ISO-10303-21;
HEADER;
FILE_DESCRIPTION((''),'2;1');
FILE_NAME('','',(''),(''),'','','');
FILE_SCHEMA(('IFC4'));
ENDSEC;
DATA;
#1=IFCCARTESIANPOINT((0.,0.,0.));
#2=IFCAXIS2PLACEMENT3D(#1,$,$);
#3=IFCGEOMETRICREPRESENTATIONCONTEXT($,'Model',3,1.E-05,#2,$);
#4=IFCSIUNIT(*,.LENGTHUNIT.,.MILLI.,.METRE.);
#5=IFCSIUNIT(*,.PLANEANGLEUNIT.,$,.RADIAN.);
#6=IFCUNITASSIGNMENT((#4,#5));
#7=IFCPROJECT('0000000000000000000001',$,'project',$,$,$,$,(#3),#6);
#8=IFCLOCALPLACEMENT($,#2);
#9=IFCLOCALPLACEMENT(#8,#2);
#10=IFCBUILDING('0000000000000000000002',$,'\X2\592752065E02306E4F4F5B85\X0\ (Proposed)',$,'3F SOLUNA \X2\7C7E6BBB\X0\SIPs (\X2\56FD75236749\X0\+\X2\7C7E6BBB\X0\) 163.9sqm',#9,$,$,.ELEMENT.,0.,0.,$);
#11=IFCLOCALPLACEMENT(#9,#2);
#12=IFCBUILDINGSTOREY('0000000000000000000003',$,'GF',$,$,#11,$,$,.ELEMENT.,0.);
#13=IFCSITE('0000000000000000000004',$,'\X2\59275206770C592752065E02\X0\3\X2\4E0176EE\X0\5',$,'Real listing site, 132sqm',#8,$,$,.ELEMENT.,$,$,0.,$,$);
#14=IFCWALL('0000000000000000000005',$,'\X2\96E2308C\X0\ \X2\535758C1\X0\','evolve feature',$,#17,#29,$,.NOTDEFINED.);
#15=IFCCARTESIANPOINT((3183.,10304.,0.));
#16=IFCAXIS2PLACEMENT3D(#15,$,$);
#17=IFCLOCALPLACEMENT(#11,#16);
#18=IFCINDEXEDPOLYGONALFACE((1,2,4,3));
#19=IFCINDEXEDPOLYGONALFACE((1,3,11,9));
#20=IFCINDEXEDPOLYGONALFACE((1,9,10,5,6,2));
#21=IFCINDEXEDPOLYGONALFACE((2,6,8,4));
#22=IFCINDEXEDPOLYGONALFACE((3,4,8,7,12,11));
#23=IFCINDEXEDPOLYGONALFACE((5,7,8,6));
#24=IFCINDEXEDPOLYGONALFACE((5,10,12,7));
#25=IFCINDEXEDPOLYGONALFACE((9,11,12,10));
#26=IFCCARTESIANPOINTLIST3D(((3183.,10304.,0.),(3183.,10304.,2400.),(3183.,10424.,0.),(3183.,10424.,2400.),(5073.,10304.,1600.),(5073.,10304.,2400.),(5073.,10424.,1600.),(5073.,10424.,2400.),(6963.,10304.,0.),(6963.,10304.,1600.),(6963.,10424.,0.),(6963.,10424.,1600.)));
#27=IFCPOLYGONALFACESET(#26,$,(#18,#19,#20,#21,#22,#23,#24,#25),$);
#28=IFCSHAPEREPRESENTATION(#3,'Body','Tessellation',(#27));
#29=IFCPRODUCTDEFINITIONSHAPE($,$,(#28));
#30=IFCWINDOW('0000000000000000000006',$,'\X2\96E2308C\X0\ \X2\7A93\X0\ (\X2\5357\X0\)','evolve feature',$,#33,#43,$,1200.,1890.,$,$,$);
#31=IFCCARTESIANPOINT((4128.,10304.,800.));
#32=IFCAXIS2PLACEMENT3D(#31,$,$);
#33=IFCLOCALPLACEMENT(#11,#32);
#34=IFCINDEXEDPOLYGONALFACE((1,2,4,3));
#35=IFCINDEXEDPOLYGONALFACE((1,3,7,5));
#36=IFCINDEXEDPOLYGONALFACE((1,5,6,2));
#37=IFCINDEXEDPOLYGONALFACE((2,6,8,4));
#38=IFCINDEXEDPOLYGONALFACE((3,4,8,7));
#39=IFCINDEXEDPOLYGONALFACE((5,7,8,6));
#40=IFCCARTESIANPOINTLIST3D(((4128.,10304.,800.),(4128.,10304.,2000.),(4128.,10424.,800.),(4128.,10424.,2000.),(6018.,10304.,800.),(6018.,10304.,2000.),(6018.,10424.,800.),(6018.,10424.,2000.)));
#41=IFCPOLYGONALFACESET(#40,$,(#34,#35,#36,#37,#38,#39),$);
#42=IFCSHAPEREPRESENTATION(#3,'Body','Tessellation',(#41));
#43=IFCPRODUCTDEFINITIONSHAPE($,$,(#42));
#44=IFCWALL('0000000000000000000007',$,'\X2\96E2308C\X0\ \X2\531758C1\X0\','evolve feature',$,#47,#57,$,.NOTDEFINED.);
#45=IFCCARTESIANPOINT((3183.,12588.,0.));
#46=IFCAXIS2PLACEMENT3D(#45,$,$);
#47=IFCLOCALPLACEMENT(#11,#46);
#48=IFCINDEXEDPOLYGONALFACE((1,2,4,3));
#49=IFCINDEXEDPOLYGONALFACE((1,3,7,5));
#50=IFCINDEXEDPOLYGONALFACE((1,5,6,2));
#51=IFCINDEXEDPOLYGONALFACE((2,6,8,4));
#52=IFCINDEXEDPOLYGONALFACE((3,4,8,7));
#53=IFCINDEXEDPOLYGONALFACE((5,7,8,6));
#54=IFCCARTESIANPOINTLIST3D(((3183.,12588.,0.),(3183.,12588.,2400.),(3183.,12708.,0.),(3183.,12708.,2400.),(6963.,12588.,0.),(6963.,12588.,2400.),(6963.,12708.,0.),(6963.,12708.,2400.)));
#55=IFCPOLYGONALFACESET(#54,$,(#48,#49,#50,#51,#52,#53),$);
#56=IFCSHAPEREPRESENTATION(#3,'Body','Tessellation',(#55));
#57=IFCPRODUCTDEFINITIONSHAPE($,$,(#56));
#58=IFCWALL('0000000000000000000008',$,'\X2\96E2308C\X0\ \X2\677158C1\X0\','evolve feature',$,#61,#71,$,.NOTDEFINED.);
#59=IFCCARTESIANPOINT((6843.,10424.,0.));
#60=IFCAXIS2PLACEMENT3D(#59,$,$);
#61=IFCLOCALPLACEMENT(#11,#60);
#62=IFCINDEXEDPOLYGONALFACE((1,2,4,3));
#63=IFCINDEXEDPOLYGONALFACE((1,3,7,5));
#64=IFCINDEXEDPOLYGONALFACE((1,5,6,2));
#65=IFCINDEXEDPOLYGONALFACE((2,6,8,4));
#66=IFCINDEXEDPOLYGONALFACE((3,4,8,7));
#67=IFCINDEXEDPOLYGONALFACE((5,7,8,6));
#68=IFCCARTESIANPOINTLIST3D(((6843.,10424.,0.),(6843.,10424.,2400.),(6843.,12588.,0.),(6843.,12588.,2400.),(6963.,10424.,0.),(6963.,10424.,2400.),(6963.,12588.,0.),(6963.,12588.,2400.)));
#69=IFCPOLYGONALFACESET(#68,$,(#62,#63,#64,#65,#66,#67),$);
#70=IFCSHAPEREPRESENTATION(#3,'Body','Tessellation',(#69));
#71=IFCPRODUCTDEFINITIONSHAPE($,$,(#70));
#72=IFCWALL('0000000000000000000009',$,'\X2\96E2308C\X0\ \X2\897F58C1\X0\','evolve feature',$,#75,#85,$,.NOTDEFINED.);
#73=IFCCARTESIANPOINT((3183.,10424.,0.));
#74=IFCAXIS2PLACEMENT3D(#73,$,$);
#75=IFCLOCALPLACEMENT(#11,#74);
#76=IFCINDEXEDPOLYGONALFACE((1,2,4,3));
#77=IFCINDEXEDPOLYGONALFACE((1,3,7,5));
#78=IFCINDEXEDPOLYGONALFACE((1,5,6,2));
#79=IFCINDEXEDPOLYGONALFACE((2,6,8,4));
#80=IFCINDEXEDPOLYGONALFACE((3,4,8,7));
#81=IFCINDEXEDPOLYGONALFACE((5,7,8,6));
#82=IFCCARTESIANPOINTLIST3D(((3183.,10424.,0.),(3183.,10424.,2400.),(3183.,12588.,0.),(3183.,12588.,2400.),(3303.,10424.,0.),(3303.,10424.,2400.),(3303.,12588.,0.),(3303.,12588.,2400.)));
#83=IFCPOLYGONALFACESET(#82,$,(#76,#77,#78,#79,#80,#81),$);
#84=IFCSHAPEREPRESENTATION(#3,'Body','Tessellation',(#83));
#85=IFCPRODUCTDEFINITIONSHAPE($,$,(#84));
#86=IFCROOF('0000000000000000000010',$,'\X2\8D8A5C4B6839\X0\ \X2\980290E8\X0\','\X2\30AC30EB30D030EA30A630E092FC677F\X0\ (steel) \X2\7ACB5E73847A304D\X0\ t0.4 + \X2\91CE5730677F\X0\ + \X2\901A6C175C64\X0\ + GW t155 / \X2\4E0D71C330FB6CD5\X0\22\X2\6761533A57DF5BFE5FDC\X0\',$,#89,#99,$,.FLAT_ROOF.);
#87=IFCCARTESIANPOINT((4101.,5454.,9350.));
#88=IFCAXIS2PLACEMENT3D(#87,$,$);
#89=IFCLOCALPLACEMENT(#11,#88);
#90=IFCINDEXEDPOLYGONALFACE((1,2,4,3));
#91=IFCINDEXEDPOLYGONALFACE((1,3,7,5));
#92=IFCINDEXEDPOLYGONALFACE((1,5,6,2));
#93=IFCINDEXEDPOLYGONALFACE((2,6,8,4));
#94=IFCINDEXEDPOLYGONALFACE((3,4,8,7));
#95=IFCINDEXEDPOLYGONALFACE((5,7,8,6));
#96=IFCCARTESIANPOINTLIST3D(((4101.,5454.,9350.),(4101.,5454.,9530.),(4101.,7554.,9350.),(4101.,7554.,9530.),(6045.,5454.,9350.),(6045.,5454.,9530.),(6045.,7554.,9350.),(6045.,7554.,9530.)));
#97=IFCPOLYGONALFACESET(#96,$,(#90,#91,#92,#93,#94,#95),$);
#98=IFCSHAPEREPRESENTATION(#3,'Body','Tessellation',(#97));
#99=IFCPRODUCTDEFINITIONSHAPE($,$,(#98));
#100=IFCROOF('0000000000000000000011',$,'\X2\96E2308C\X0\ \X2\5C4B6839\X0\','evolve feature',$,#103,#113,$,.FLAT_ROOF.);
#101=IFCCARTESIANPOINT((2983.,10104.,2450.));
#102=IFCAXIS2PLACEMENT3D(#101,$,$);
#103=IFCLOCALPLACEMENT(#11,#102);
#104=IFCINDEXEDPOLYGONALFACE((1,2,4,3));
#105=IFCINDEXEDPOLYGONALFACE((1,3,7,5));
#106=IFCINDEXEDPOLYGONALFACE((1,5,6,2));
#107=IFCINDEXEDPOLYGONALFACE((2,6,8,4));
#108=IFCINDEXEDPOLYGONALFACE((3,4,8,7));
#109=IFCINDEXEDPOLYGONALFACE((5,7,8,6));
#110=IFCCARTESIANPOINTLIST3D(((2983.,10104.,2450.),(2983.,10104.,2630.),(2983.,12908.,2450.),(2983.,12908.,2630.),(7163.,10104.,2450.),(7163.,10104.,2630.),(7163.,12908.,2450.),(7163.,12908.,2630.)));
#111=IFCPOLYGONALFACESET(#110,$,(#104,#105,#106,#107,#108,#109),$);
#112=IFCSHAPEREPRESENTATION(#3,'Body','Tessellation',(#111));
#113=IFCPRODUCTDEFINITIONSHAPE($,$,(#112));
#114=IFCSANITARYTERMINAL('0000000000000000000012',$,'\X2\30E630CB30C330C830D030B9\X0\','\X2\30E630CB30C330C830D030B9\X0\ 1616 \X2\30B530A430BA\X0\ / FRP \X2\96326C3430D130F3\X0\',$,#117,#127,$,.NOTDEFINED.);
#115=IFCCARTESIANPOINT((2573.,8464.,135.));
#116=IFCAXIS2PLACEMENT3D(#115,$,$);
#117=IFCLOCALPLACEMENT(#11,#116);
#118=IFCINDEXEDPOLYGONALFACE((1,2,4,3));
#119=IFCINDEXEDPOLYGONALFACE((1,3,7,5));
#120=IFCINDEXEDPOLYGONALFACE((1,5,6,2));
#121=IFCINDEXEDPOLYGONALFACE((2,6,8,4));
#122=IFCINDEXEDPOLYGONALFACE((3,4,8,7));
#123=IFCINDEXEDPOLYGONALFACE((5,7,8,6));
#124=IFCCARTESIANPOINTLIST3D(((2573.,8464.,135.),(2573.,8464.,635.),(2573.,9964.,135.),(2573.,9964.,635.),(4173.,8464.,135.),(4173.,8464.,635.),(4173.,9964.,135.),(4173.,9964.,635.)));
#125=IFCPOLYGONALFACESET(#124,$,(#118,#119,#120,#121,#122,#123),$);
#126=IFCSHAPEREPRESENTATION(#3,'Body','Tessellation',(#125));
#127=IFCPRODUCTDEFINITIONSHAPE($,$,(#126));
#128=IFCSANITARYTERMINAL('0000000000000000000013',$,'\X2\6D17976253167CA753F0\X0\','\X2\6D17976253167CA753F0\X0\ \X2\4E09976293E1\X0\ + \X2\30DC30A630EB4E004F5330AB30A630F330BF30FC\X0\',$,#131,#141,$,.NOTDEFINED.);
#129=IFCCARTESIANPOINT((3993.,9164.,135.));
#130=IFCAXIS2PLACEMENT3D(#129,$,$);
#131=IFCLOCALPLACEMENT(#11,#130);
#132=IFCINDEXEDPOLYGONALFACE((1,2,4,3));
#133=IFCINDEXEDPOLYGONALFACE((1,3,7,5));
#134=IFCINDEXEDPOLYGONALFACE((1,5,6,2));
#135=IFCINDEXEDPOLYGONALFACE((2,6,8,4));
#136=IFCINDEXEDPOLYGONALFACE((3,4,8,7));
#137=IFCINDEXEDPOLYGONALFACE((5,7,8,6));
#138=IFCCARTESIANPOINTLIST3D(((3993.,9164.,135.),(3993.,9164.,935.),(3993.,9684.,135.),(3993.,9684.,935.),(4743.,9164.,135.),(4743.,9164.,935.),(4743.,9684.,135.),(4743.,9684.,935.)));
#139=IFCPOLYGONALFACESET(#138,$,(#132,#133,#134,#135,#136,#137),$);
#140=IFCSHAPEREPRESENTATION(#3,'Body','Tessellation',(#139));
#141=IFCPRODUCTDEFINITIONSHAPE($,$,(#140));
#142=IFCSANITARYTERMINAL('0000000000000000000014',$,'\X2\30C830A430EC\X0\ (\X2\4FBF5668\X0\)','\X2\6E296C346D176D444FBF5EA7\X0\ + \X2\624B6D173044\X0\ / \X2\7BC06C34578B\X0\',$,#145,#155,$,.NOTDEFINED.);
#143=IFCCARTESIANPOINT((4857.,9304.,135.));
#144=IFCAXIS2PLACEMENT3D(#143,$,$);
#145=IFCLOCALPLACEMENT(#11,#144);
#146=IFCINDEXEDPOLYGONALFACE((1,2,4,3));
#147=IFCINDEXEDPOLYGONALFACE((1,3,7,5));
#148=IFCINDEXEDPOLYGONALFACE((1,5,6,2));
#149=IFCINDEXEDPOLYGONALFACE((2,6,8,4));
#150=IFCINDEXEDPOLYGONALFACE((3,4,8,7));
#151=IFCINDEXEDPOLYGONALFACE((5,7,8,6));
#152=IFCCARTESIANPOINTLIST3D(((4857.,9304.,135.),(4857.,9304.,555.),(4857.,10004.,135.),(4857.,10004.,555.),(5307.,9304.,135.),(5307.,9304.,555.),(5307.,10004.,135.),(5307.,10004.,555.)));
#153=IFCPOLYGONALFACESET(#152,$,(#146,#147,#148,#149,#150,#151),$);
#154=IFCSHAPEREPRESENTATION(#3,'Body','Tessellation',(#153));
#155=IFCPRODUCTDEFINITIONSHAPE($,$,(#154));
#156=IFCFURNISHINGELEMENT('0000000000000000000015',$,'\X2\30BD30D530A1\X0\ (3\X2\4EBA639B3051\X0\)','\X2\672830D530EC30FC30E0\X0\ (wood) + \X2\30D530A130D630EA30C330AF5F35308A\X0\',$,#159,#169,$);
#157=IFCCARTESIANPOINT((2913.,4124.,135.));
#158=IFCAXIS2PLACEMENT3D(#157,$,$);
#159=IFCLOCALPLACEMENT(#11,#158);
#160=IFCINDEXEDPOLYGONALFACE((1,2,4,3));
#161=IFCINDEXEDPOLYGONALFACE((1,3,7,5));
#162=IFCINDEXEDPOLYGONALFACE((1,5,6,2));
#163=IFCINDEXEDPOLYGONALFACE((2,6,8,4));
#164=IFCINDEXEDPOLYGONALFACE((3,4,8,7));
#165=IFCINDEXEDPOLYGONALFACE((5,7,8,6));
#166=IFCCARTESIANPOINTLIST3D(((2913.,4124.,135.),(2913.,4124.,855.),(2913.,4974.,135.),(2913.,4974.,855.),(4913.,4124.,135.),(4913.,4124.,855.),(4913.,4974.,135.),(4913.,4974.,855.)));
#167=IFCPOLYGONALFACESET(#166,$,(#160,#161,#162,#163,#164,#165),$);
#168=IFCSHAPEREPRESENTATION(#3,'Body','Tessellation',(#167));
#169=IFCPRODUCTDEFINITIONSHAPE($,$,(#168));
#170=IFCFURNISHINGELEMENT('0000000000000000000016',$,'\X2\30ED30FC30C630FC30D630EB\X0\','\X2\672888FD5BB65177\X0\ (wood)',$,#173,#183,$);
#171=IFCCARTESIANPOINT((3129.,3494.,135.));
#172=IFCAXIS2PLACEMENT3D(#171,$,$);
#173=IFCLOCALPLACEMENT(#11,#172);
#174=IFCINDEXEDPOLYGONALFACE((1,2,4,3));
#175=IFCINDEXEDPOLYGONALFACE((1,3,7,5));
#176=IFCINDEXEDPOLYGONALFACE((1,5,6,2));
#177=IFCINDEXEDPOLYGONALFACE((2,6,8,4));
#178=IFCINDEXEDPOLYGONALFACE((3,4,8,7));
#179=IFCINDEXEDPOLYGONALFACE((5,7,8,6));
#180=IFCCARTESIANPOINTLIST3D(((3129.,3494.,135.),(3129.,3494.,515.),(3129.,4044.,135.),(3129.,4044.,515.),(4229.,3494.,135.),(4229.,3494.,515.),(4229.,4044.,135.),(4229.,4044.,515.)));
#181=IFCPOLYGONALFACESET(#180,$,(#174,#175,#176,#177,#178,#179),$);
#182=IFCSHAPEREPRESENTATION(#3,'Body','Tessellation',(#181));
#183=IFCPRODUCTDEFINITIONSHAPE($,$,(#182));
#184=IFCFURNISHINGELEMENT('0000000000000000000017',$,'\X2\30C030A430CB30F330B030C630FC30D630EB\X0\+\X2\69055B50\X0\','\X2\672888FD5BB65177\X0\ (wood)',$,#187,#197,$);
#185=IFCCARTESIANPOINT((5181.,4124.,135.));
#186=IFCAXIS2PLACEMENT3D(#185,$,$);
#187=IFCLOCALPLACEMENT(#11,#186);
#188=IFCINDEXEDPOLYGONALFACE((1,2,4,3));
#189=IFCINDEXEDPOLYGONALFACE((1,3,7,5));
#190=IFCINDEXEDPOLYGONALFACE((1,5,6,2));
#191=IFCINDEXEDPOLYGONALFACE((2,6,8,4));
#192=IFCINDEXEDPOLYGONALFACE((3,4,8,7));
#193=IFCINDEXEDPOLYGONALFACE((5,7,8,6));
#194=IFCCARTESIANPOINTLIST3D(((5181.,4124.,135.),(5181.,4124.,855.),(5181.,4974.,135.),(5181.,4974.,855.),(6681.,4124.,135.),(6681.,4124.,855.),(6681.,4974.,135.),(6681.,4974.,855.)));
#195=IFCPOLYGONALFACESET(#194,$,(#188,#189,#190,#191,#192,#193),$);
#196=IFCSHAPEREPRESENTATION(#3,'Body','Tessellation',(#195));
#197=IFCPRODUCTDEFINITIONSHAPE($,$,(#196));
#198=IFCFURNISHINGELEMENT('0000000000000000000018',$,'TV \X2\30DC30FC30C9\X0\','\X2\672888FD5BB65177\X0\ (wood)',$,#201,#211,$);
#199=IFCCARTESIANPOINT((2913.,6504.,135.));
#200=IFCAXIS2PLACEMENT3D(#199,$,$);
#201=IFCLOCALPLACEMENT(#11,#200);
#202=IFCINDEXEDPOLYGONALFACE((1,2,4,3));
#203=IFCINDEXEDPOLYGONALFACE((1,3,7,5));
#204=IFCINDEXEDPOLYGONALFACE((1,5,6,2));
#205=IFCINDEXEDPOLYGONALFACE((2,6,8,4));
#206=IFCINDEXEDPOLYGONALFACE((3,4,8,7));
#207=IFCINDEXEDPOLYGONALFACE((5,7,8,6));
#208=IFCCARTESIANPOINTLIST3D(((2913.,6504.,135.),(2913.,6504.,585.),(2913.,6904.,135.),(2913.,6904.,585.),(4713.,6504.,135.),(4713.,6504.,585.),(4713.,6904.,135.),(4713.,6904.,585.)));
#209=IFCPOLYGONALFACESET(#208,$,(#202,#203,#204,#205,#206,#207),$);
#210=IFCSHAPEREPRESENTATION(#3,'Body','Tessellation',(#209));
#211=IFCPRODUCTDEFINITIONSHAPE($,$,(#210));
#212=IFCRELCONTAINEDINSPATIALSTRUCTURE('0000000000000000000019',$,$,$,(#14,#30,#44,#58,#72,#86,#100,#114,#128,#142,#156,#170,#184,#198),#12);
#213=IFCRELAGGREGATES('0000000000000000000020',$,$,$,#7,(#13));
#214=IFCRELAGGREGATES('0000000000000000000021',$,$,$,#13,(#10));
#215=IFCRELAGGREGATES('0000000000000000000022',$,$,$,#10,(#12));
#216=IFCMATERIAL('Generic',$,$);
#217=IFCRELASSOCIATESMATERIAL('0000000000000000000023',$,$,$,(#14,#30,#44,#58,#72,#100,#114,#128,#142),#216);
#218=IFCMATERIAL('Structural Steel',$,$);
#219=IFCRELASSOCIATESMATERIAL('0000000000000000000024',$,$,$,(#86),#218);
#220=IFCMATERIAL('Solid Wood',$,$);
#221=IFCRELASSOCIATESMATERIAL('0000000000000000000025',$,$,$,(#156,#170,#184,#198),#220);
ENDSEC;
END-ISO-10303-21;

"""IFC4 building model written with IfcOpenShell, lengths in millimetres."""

from ifc_helpers import new_model, si_unit, frame, frame_2d, origin, place, context, project, spatial, rectangle, extrude, material, element, fill, save


model = new_model("IFC4")

# Units and contexts
model_context = context("Model", 3, precision=1e-05, world=origin())
ifc_project = project(units=[si_unit("LENGTHUNIT", "METRE", prefix="MILLI"), si_unit("PLANEANGLEUNIT", "RADIAN")], contexts=[model_context])

# Site, building, storey
site_placement = place(None, origin())
site = spatial("IfcSite", under=ifc_project, at=site_placement, Name="大分県大分市3丁目5", ObjectType="Real listing site, 132sqm", CompositionType="ELEMENT", RefElevation=0.0)
building_placement = place(site_placement, origin())
building = spatial("IfcBuilding", under=site, at=building_placement, Name="大分市の住宅 (Proposed)", ObjectType="3F SOLUNA 籾殻SIPs (国産杉+籾殻) 163.9sqm", CompositionType="ELEMENT", ElevationOfRefHeight=0.0, ElevationOfTerrain=0.0)
storey_placement = place(building_placement, origin())
storey = spatial("IfcBuildingStorey", under=building, at=storey_placement, Name="GF", CompositionType="ELEMENT", Elevation=0.0)

# Shared definitions
ifc_material_1 = material(Name="Generic")

# Shared definitions
ifc_material_2 = material(Name="Solid Wood")

# Wall, opening, window
wall_1_placement = place(storey_placement, frame((3183.0, 10304.0, 0.0)))
wall_1 = element("IfcWall", 1, at=wall_1_placement, inside=storey, material=ifc_material_1, Name="離れ 南壁", Description="evolve feature", PredefinedType="NOTDEFINED", context=model_context, shape_type="SweptSolid", body=[
    extrude(rectangle(XDim=3780.0, YDim=120.0, at=frame_2d((1890.0, 60.0))), frame((3183.0, 10304.0, 0.0)), (0.0, 0.0, 1.0), 2400.0),
])
opening_1_placement = place(storey_placement, frame((4128.0, 10304.0, 800.0)))
opening_1 = element("IfcOpeningElement", 2, at=opening_1_placement, cuts=wall_1, PredefinedType="NOTDEFINED", context=model_context, shape_type="SweptSolid", body=[
    extrude(rectangle(XDim=1890.0, YDim=120.0, at=frame_2d((945.0, 60.0))), frame((4128.0, 10304.0, 800.0)), (0.0, 0.0, 1.0), 1200.0),
])
window_1_placement = place(storey_placement, frame((4128.0, 10304.0, 800.0)))
window_1 = element("IfcWindow", 3, at=window_1_placement, inside=storey, material=ifc_material_1, Name="離れ 窓 (南)", Description="evolve feature", OverallHeight=1200.0, OverallWidth=1890.0, context=model_context, shape_type="SweptSolid", body=[
    extrude(rectangle(XDim=1890.0, YDim=120.0, at=frame_2d((945.0, 60.0))), frame((4128.0, 10304.0, 800.0)), (0.0, 0.0, 1.0), 1200.0),
])
fill(opening_1, window_1)

# Walls
wall_2_placement = place(storey_placement, frame((3183.0, 12588.0, 0.0)))
element("IfcWall", 4, at=wall_2_placement, inside=storey, material=ifc_material_1, Name="離れ 北壁", Description="evolve feature", PredefinedType="NOTDEFINED", context=model_context, shape_type="SweptSolid", body=[
    extrude(rectangle(XDim=3780.0, YDim=120.0, at=frame_2d((1890.0, 60.0))), frame((3183.0, 12588.0, 0.0)), (0.0, 0.0, 1.0), 2400.0),
])
wall_3_placement = place(storey_placement, frame((6843.0, 10424.0, 0.0)))
element("IfcWall", 5, at=wall_3_placement, inside=storey, material=ifc_material_1, Name="離れ 東壁", Description="evolve feature", PredefinedType="NOTDEFINED", context=model_context, shape_type="SweptSolid", body=[
    extrude(rectangle(XDim=120.0, YDim=2164.0, at=frame_2d((60.0, 1082.0))), frame((6843.0, 10424.0, 0.0)), (0.0, 0.0, 1.0), 2400.0),
])
wall_4_placement = place(storey_placement, frame((3183.0, 10424.0, 0.0)))
element("IfcWall", 6, at=wall_4_placement, inside=storey, material=ifc_material_1, Name="離れ 西壁", Description="evolve feature", PredefinedType="NOTDEFINED", context=model_context, shape_type="SweptSolid", body=[
    extrude(rectangle(XDim=120.0, YDim=2164.0, at=frame_2d((60.0, 1082.0))), frame((3183.0, 10424.0, 0.0)), (0.0, 0.0, 1.0), 2400.0),
])

# Roofs
ifc_material_3 = material(Name="Structural Steel")
roof_1_placement = place(storey_placement, frame((4101.0, 5454.0, 9350.0)))
element("IfcRoof", 7, at=roof_1_placement, inside=storey, material=ifc_material_3, Name="越屋根 頂部", Description="ガルバリウム鋼板 (steel) 立平葺き t0.4 + 野地板 + 通気層 + GW t155 / 不燃・法22条区域対応", PredefinedType="FLAT_ROOF", context=model_context, shape_type="SweptSolid", body=[
    extrude(rectangle(XDim=1944.0, YDim=2100.0, at=frame_2d((972.0, 1050.0))), frame((4101.0, 5454.0, 9350.0)), (0.0, 0.0, 1.0), 180.0),
])
roof_2_placement = place(storey_placement, frame((2983.0, 10104.0, 2450.0)))
element("IfcRoof", 8, at=roof_2_placement, inside=storey, material=ifc_material_1, Name="離れ 屋根", Description="evolve feature", PredefinedType="FLAT_ROOF", context=model_context, shape_type="SweptSolid", body=[
    extrude(rectangle(XDim=4180.0, YDim=2804.0, at=frame_2d((2090.0, 1402.0))), frame((2983.0, 10104.0, 2450.0)), (0.0, 0.0, 1.0), 180.0),
])

# Sanitary terminals
sanitary_terminal_1_placement = place(storey_placement, frame((2573.0, 8464.0, 135.0)))
element("IfcSanitaryTerminal", 9, at=sanitary_terminal_1_placement, inside=storey, material=ifc_material_1, Name="ユニットバス", Description="ユニットバス 1616 サイズ / FRP 防水パン", PredefinedType="NOTDEFINED", context=model_context, shape_type="SweptSolid", body=[
    extrude(rectangle(XDim=1600.0, YDim=1500.0, at=frame_2d((800.0, 750.0))), frame((2573.0, 8464.0, 135.0)), (0.0, 0.0, 1.0), 500.0),
])
sanitary_terminal_2_placement = place(storey_placement, frame((3993.0, 9164.0, 135.0)))
element("IfcSanitaryTerminal", 10, at=sanitary_terminal_2_placement, inside=storey, material=ifc_material_1, Name="洗面化粧台", Description="洗面化粧台 三面鏡 + ボウル一体カウンター", PredefinedType="NOTDEFINED", context=model_context, shape_type="SweptSolid", body=[
    extrude(rectangle(XDim=750.0, YDim=520.0, at=frame_2d((375.0, 260.0))), frame((3993.0, 9164.0, 135.0)), (0.0, 0.0, 1.0), 800.0),
])
sanitary_terminal_3_placement = place(storey_placement, frame((4857.0, 9304.0, 135.0)))
element("IfcSanitaryTerminal", 11, at=sanitary_terminal_3_placement, inside=storey, material=ifc_material_1, Name="トイレ (便器)", Description="温水洗浄便座 + 手洗い / 節水型", PredefinedType="NOTDEFINED", context=model_context, shape_type="SweptSolid", body=[
    extrude(rectangle(XDim=450.0, YDim=700.0, at=frame_2d((225.0, 350.0))), frame((4857.0, 9304.0, 135.0)), (0.0, 0.0, 1.0), 420.0),
])

# Furnishing elements
furnishing_1_placement = place(storey_placement, frame((2913.0, 4124.0, 135.0)))
element("IfcFurnishingElement", 12, at=furnishing_1_placement, inside=storey, material=ifc_material_2, Name="ソファ (3人掛け)", Description="木フレーム (wood) + ファブリック張り", context=model_context, shape_type="SweptSolid", body=[
    extrude(rectangle(XDim=2000.0, YDim=850.0, at=frame_2d((1000.0, 425.0))), frame((2913.0, 4124.0, 135.0)), (0.0, 0.0, 1.0), 720.0),
])
furnishing_2_placement = place(storey_placement, frame((3129.0, 3494.0, 135.0)))
element("IfcFurnishingElement", 13, at=furnishing_2_placement, inside=storey, material=ifc_material_2, Name="ローテーブル", Description="木製家具 (wood)", context=model_context, shape_type="SweptSolid", body=[
    extrude(rectangle(XDim=1100.0, YDim=550.0, at=frame_2d((550.0, 275.0))), frame((3129.0, 3494.0, 135.0)), (0.0, 0.0, 1.0), 380.0),
])
furnishing_3_placement = place(storey_placement, frame((5181.0, 4124.0, 135.0)))
element("IfcFurnishingElement", 14, at=furnishing_3_placement, inside=storey, material=ifc_material_2, Name="ダイニングテーブル+椅子", Description="木製家具 (wood)", context=model_context, shape_type="SweptSolid", body=[
    extrude(rectangle(XDim=1500.0, YDim=850.0, at=frame_2d((750.0, 425.0))), frame((5181.0, 4124.0, 135.0)), (0.0, 0.0, 1.0), 720.0),
])
furnishing_4_placement = place(storey_placement, frame((2913.0, 6504.0, 135.0)))
element("IfcFurnishingElement", 15, at=furnishing_4_placement, inside=storey, material=ifc_material_2, Name="TV ボード", Description="木製家具 (wood)", context=model_context, shape_type="SweptSolid", body=[
    extrude(rectangle(XDim=1800.0, YDim=400.0, at=frame_2d((900.0, 200.0))), frame((2913.0, 6504.0, 135.0)), (0.0, 0.0, 1.0), 450.0),
])

save(model, "model.ifc")
